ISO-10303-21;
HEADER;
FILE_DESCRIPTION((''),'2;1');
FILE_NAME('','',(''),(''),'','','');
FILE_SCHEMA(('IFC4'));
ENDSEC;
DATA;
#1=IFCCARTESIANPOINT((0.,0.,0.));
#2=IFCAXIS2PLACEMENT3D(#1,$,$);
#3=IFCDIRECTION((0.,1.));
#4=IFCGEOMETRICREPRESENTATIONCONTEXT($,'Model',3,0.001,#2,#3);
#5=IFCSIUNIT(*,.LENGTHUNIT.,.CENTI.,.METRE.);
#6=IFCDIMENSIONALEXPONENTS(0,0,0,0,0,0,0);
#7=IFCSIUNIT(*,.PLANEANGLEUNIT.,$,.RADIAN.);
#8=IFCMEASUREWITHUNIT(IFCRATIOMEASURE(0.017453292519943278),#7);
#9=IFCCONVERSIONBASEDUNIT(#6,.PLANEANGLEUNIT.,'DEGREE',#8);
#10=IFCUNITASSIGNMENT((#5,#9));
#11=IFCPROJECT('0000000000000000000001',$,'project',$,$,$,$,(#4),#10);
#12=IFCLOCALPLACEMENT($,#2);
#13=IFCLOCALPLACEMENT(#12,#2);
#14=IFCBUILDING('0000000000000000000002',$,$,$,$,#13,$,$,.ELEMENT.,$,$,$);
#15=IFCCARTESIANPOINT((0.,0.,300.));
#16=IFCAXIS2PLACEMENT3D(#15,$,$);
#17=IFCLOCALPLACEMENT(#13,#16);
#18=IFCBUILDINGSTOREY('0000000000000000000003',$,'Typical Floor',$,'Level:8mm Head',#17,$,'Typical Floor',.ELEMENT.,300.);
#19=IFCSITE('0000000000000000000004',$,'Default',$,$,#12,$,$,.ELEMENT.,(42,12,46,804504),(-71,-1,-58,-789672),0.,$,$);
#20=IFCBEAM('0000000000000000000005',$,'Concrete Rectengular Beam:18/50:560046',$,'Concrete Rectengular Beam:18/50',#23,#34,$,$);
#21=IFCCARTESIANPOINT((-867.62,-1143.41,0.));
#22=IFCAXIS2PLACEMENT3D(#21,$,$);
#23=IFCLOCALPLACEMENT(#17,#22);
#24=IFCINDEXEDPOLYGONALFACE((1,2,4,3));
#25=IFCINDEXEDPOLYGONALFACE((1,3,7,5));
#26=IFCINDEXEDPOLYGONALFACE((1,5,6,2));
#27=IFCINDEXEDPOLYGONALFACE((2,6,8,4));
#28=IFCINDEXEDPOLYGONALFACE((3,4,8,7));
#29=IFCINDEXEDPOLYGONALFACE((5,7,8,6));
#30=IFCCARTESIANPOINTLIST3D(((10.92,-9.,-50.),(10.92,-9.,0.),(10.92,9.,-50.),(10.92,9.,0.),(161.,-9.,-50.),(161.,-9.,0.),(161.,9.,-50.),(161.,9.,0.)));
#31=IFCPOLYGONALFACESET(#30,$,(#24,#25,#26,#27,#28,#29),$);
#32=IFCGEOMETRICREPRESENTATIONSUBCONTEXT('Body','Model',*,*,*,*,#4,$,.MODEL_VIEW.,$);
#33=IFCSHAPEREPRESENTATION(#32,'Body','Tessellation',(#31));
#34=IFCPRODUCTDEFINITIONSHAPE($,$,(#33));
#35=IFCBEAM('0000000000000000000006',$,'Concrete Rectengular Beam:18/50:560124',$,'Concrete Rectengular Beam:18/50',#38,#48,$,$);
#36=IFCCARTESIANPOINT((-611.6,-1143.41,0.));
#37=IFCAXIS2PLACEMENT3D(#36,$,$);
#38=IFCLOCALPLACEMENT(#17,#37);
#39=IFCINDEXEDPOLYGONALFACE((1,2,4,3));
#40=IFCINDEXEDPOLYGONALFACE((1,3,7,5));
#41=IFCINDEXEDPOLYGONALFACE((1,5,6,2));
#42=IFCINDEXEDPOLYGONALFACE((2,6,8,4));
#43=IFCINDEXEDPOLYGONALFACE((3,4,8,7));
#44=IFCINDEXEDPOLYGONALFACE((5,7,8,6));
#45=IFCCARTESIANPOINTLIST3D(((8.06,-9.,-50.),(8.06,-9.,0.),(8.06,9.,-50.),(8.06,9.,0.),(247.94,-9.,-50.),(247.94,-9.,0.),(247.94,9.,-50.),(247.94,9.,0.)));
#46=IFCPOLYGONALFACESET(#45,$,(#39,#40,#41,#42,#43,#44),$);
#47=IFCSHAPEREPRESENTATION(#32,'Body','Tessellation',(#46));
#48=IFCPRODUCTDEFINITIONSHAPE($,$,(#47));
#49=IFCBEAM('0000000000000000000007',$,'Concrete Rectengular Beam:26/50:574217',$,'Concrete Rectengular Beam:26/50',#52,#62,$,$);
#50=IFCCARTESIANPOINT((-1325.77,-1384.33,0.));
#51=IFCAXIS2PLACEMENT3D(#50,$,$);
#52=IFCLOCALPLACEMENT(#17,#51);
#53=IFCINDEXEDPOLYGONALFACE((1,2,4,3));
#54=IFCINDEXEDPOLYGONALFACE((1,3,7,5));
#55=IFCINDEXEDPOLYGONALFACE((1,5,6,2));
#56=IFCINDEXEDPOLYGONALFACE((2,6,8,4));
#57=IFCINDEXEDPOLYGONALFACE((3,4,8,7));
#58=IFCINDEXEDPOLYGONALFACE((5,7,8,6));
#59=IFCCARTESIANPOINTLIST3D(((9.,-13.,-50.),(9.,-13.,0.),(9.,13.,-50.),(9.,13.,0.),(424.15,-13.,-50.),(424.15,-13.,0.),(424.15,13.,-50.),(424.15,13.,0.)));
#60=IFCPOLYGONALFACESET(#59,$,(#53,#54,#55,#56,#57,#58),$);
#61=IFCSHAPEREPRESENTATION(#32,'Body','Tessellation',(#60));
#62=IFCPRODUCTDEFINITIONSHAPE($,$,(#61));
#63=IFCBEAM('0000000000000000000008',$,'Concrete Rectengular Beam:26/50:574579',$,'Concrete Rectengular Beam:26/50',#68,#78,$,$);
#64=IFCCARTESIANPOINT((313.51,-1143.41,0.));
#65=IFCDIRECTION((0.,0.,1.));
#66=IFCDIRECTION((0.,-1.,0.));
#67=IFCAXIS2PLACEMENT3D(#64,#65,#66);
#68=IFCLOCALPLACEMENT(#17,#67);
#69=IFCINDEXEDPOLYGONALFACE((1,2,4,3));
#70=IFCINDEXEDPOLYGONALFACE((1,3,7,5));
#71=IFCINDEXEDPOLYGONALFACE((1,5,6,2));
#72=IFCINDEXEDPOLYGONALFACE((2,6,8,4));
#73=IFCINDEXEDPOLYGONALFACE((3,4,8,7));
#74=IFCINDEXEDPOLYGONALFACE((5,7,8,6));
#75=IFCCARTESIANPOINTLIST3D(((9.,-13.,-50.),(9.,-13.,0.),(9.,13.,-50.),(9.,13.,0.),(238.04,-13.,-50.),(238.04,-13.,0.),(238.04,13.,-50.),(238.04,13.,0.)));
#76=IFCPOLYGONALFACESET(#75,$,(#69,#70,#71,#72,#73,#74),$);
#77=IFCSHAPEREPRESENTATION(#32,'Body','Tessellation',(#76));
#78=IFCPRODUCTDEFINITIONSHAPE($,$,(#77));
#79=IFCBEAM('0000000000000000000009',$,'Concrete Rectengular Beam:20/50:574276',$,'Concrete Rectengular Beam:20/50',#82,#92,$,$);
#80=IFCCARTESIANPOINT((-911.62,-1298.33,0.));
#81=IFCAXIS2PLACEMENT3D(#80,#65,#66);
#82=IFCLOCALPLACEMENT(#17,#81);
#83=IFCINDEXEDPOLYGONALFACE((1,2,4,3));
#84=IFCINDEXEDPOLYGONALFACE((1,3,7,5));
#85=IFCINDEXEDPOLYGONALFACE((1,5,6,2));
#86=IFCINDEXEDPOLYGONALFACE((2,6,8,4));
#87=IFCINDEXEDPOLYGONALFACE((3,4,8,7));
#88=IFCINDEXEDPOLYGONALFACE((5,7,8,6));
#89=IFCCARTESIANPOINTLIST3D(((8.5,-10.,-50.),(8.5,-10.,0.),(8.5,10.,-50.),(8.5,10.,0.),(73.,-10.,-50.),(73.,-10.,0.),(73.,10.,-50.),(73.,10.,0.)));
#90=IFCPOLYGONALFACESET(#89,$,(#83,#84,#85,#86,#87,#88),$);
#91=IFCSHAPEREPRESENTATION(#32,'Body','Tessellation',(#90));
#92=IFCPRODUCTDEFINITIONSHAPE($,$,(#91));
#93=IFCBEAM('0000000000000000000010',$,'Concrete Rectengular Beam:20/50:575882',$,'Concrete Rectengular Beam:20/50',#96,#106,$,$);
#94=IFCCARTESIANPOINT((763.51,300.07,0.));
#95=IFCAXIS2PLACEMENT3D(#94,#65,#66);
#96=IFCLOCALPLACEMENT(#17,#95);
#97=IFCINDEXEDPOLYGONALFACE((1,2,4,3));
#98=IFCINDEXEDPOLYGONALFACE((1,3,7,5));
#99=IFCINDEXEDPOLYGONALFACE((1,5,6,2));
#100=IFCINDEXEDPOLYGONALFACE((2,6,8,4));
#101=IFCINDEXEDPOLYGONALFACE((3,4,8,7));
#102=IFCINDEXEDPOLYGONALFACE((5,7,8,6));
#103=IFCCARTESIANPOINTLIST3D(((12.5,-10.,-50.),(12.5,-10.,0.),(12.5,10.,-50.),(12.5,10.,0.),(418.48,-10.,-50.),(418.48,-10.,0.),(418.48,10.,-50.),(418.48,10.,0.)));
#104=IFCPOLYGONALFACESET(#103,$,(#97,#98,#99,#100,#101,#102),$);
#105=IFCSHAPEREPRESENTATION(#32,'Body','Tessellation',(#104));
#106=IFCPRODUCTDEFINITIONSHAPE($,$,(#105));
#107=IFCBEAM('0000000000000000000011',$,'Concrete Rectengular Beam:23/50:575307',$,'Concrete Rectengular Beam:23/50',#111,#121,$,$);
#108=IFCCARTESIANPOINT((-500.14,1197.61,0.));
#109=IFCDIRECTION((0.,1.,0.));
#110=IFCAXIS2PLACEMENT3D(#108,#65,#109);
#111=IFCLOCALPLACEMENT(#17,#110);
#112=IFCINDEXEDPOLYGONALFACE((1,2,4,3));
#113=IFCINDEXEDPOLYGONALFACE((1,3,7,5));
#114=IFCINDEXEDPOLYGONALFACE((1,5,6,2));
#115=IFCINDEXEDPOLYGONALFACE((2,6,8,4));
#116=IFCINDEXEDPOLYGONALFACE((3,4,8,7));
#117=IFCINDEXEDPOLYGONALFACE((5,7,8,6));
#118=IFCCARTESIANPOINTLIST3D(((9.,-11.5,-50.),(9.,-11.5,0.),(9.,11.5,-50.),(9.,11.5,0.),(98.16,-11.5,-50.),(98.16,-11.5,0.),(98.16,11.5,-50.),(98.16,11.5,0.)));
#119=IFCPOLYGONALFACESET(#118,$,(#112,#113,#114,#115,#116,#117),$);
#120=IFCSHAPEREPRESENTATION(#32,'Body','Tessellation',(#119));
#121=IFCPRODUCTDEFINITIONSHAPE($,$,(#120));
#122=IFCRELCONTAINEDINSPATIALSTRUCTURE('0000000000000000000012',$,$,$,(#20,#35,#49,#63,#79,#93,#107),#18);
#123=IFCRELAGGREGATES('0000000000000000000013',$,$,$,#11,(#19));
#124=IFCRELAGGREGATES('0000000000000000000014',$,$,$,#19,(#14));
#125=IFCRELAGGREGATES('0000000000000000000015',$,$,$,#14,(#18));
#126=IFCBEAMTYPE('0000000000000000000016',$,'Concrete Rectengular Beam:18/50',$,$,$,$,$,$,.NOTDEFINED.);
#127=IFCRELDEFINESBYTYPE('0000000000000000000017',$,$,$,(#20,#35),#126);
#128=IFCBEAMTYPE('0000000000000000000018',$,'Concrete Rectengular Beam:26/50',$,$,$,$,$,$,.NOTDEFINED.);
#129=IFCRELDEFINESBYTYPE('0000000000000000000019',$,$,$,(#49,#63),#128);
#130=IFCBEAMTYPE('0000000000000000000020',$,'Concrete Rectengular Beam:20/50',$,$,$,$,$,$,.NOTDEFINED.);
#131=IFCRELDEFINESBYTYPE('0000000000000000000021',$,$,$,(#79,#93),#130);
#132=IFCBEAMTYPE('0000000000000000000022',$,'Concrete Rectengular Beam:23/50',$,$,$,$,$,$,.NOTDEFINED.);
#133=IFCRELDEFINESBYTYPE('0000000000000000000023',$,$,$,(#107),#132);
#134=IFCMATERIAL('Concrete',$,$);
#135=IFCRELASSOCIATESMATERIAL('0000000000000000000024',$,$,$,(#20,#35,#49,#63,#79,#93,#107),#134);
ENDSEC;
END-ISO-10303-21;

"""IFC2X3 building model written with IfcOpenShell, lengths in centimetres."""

from ifc_helpers import new_model, entity, si_unit, converted_unit, direction, frame, frame_2d, origin, origin_2d_with_axis, place, context, subcontext, project, spatial, rectangle, extrude, material, type_object, element, save


model = new_model("IFC2X3")

# Units and contexts
model_context = context("Model", 3, precision=0.001, world=origin(), true_north=direction((0.0, 1.0)))
body_context = subcontext(model_context, "Body", "Model", "MODEL_VIEW")
ifc_project = project(units=[si_unit("LENGTHUNIT", "METRE", prefix="CENTI"), converted_unit("PLANEANGLEUNIT", "DEGREE", entity("IfcRatioMeasure", 0.017453292519943278), si_unit("PLANEANGLEUNIT", "RADIAN"), dimensions=[0, 0, 0, 0, 0, 0, 0])], contexts=[model_context])

# Site, building, storey
site_placement = place(None, origin())
site = spatial("IfcSite", under=ifc_project, at=site_placement, Name="Default", CompositionType="ELEMENT", RefLatitude=(42, 12, 46, 804504), RefLongitude=(-71, -1, -58, -789672), RefElevation=0.0)
building_placement = place(site_placement, origin())
building = spatial("IfcBuilding", under=site, at=building_placement, CompositionType="ELEMENT")
storey_placement = place(building_placement, frame((0.0, 0.0, 300.0)))
storey = spatial("IfcBuildingStorey", under=building, at=storey_placement, Name="Typical Floor", ObjectType="Level:8mm Head", LongName="Typical Floor", CompositionType="ELEMENT", Elevation=300.0)

# Beams
ifc_material = material(Name="Concrete")
beam_type_1 = type_object("IfcBeamType", Name="Concrete Rectengular Beam:18/50", PredefinedType="NOTDEFINED")
beam_1_placement = place(storey_placement, frame((-867.62, -1143.41, 0.0)))
element("IfcBeam", 1, at=beam_1_placement, inside=storey, type_object=beam_type_1, material=ifc_material, Name="Concrete Rectengular Beam:18/50:560046", ObjectType="Concrete Rectengular Beam:18/50", context=body_context, shape_type="SweptSolid", body=[
    extrude(rectangle(XDim=50.0, YDim=18.0, at=frame_2d((0.0, 0.0), x_axis=(1.0, 0.0))), frame((10.92, 0.0, -25.0), z_axis=(1.0, 0.0, 0.0), x_axis=(0.0, 0.0, -1.0)), (0.0, 0.0, 1.0), 150.08),
])
beam_2_placement = place(storey_placement, frame((-611.6, -1143.41, 0.0)))
element("IfcBeam", 2, at=beam_2_placement, inside=storey, type_object=beam_type_1, material=ifc_material, Name="Concrete Rectengular Beam:18/50:560124", ObjectType="Concrete Rectengular Beam:18/50", context=body_context, shape_type="SweptSolid", body=[
    extrude(rectangle(XDim=50.0, YDim=18.0, at=frame_2d((0.0, 0.0), x_axis=(1.0, 0.0))), frame((8.06, 0.0, -25.0), z_axis=(1.0, 0.0, 0.0), x_axis=(0.0, 0.0, -1.0)), (0.0, 0.0, 1.0), 239.88),
])
beam_type_2 = type_object("IfcBeamType", Name="Concrete Rectengular Beam:26/50", PredefinedType="NOTDEFINED")
beam_3_placement = place(storey_placement, frame((-1325.77, -1384.33, 0.0)))
element("IfcBeam", 3, at=beam_3_placement, inside=storey, type_object=beam_type_2, material=ifc_material, Name="Concrete Rectengular Beam:26/50:574217", ObjectType="Concrete Rectengular Beam:26/50", context=body_context, shape_type="SweptSolid", body=[
    extrude(rectangle(XDim=50.0, YDim=26.0, at=frame_2d((0.0, 0.0), x_axis=(1.0, 0.0))), frame((9.0, 0.0, -25.0), z_axis=(1.0, 0.0, 0.0), x_axis=(0.0, 0.0, -1.0)), (0.0, 0.0, 1.0), 415.15),
])
beam_4_placement = place(storey_placement, frame((313.51, -1143.41, 0.0), z_axis=(0.0, 0.0, 1.0), x_axis=(0.0, -1.0, 0.0)))
element("IfcBeam", 4, at=beam_4_placement, inside=storey, type_object=beam_type_2, material=ifc_material, Name="Concrete Rectengular Beam:26/50:574579", ObjectType="Concrete Rectengular Beam:26/50", context=body_context, shape_type="SweptSolid", body=[
    extrude(rectangle(XDim=50.0, YDim=26.0, at=frame_2d((0.0, 0.0), x_axis=(1.0, 0.0))), frame((9.0, 0.0, -25.0), z_axis=(1.0, 0.0, 0.0), x_axis=(0.0, 0.0, -1.0)), (0.0, 0.0, 1.0), 229.04),
])
beam_type_3 = type_object("IfcBeamType", Name="Concrete Rectengular Beam:20/50", PredefinedType="NOTDEFINED")
beam_5_placement = place(storey_placement, frame((-911.62, -1298.33, 0.0), z_axis=(0.0, 0.0, 1.0), x_axis=(0.0, -1.0, 0.0)))
element("IfcBeam", 5, at=beam_5_placement, inside=storey, type_object=beam_type_3, material=ifc_material, Name="Concrete Rectengular Beam:20/50:574276", ObjectType="Concrete Rectengular Beam:20/50", context=body_context, shape_type="SweptSolid", body=[
    extrude(rectangle(XDim=50.0, YDim=20.0, at=frame_2d((0.0, 0.0), x_axis=(1.0, 0.0))), frame((8.5, 0.0, -25.0), z_axis=(1.0, 0.0, 0.0), x_axis=(0.0, 0.0, -1.0)), (0.0, 0.0, 1.0), 64.5),
])
beam_6_placement = place(storey_placement, frame((763.51, 300.07, 0.0), z_axis=(0.0, 0.0, 1.0), x_axis=(0.0, -1.0, 0.0)))
element("IfcBeam", 6, at=beam_6_placement, inside=storey, type_object=beam_type_3, material=ifc_material, Name="Concrete Rectengular Beam:20/50:575882", ObjectType="Concrete Rectengular Beam:20/50", context=body_context, shape_type="SweptSolid", body=[
    extrude(rectangle(XDim=50.0, YDim=20.0, at=frame_2d((0.0, 0.0), x_axis=(1.0, 0.0))), frame((12.5, 0.0, -25.0), z_axis=(1.0, 0.0, 0.0), x_axis=(0.0, 0.0, -1.0)), (0.0, 0.0, 1.0), 405.98),
])
beam_type_4 = type_object("IfcBeamType", Name="Concrete Rectengular Beam:23/50", PredefinedType="NOTDEFINED")
beam_7_placement = place(storey_placement, frame((-500.14, 1197.61, 0.0), z_axis=(0.0, 0.0, 1.0), x_axis=(0.0, 1.0, 0.0)))
element("IfcBeam", 7, at=beam_7_placement, inside=storey, type_object=beam_type_4, material=ifc_material, Name="Concrete Rectengular Beam:23/50:575307", ObjectType="Concrete Rectengular Beam:23/50", context=body_context, shape_type="SweptSolid", body=[
    extrude(rectangle(XDim=50.0, YDim=23.0, at=origin_2d_with_axis()), frame((9.0, 0.0, -25.0), z_axis=(1.0, 0.0, 0.0), x_axis=(0.0, 0.0, -1.0)), (0.0, 0.0, 1.0), 89.16),
])

save(model, "model.ifc")
